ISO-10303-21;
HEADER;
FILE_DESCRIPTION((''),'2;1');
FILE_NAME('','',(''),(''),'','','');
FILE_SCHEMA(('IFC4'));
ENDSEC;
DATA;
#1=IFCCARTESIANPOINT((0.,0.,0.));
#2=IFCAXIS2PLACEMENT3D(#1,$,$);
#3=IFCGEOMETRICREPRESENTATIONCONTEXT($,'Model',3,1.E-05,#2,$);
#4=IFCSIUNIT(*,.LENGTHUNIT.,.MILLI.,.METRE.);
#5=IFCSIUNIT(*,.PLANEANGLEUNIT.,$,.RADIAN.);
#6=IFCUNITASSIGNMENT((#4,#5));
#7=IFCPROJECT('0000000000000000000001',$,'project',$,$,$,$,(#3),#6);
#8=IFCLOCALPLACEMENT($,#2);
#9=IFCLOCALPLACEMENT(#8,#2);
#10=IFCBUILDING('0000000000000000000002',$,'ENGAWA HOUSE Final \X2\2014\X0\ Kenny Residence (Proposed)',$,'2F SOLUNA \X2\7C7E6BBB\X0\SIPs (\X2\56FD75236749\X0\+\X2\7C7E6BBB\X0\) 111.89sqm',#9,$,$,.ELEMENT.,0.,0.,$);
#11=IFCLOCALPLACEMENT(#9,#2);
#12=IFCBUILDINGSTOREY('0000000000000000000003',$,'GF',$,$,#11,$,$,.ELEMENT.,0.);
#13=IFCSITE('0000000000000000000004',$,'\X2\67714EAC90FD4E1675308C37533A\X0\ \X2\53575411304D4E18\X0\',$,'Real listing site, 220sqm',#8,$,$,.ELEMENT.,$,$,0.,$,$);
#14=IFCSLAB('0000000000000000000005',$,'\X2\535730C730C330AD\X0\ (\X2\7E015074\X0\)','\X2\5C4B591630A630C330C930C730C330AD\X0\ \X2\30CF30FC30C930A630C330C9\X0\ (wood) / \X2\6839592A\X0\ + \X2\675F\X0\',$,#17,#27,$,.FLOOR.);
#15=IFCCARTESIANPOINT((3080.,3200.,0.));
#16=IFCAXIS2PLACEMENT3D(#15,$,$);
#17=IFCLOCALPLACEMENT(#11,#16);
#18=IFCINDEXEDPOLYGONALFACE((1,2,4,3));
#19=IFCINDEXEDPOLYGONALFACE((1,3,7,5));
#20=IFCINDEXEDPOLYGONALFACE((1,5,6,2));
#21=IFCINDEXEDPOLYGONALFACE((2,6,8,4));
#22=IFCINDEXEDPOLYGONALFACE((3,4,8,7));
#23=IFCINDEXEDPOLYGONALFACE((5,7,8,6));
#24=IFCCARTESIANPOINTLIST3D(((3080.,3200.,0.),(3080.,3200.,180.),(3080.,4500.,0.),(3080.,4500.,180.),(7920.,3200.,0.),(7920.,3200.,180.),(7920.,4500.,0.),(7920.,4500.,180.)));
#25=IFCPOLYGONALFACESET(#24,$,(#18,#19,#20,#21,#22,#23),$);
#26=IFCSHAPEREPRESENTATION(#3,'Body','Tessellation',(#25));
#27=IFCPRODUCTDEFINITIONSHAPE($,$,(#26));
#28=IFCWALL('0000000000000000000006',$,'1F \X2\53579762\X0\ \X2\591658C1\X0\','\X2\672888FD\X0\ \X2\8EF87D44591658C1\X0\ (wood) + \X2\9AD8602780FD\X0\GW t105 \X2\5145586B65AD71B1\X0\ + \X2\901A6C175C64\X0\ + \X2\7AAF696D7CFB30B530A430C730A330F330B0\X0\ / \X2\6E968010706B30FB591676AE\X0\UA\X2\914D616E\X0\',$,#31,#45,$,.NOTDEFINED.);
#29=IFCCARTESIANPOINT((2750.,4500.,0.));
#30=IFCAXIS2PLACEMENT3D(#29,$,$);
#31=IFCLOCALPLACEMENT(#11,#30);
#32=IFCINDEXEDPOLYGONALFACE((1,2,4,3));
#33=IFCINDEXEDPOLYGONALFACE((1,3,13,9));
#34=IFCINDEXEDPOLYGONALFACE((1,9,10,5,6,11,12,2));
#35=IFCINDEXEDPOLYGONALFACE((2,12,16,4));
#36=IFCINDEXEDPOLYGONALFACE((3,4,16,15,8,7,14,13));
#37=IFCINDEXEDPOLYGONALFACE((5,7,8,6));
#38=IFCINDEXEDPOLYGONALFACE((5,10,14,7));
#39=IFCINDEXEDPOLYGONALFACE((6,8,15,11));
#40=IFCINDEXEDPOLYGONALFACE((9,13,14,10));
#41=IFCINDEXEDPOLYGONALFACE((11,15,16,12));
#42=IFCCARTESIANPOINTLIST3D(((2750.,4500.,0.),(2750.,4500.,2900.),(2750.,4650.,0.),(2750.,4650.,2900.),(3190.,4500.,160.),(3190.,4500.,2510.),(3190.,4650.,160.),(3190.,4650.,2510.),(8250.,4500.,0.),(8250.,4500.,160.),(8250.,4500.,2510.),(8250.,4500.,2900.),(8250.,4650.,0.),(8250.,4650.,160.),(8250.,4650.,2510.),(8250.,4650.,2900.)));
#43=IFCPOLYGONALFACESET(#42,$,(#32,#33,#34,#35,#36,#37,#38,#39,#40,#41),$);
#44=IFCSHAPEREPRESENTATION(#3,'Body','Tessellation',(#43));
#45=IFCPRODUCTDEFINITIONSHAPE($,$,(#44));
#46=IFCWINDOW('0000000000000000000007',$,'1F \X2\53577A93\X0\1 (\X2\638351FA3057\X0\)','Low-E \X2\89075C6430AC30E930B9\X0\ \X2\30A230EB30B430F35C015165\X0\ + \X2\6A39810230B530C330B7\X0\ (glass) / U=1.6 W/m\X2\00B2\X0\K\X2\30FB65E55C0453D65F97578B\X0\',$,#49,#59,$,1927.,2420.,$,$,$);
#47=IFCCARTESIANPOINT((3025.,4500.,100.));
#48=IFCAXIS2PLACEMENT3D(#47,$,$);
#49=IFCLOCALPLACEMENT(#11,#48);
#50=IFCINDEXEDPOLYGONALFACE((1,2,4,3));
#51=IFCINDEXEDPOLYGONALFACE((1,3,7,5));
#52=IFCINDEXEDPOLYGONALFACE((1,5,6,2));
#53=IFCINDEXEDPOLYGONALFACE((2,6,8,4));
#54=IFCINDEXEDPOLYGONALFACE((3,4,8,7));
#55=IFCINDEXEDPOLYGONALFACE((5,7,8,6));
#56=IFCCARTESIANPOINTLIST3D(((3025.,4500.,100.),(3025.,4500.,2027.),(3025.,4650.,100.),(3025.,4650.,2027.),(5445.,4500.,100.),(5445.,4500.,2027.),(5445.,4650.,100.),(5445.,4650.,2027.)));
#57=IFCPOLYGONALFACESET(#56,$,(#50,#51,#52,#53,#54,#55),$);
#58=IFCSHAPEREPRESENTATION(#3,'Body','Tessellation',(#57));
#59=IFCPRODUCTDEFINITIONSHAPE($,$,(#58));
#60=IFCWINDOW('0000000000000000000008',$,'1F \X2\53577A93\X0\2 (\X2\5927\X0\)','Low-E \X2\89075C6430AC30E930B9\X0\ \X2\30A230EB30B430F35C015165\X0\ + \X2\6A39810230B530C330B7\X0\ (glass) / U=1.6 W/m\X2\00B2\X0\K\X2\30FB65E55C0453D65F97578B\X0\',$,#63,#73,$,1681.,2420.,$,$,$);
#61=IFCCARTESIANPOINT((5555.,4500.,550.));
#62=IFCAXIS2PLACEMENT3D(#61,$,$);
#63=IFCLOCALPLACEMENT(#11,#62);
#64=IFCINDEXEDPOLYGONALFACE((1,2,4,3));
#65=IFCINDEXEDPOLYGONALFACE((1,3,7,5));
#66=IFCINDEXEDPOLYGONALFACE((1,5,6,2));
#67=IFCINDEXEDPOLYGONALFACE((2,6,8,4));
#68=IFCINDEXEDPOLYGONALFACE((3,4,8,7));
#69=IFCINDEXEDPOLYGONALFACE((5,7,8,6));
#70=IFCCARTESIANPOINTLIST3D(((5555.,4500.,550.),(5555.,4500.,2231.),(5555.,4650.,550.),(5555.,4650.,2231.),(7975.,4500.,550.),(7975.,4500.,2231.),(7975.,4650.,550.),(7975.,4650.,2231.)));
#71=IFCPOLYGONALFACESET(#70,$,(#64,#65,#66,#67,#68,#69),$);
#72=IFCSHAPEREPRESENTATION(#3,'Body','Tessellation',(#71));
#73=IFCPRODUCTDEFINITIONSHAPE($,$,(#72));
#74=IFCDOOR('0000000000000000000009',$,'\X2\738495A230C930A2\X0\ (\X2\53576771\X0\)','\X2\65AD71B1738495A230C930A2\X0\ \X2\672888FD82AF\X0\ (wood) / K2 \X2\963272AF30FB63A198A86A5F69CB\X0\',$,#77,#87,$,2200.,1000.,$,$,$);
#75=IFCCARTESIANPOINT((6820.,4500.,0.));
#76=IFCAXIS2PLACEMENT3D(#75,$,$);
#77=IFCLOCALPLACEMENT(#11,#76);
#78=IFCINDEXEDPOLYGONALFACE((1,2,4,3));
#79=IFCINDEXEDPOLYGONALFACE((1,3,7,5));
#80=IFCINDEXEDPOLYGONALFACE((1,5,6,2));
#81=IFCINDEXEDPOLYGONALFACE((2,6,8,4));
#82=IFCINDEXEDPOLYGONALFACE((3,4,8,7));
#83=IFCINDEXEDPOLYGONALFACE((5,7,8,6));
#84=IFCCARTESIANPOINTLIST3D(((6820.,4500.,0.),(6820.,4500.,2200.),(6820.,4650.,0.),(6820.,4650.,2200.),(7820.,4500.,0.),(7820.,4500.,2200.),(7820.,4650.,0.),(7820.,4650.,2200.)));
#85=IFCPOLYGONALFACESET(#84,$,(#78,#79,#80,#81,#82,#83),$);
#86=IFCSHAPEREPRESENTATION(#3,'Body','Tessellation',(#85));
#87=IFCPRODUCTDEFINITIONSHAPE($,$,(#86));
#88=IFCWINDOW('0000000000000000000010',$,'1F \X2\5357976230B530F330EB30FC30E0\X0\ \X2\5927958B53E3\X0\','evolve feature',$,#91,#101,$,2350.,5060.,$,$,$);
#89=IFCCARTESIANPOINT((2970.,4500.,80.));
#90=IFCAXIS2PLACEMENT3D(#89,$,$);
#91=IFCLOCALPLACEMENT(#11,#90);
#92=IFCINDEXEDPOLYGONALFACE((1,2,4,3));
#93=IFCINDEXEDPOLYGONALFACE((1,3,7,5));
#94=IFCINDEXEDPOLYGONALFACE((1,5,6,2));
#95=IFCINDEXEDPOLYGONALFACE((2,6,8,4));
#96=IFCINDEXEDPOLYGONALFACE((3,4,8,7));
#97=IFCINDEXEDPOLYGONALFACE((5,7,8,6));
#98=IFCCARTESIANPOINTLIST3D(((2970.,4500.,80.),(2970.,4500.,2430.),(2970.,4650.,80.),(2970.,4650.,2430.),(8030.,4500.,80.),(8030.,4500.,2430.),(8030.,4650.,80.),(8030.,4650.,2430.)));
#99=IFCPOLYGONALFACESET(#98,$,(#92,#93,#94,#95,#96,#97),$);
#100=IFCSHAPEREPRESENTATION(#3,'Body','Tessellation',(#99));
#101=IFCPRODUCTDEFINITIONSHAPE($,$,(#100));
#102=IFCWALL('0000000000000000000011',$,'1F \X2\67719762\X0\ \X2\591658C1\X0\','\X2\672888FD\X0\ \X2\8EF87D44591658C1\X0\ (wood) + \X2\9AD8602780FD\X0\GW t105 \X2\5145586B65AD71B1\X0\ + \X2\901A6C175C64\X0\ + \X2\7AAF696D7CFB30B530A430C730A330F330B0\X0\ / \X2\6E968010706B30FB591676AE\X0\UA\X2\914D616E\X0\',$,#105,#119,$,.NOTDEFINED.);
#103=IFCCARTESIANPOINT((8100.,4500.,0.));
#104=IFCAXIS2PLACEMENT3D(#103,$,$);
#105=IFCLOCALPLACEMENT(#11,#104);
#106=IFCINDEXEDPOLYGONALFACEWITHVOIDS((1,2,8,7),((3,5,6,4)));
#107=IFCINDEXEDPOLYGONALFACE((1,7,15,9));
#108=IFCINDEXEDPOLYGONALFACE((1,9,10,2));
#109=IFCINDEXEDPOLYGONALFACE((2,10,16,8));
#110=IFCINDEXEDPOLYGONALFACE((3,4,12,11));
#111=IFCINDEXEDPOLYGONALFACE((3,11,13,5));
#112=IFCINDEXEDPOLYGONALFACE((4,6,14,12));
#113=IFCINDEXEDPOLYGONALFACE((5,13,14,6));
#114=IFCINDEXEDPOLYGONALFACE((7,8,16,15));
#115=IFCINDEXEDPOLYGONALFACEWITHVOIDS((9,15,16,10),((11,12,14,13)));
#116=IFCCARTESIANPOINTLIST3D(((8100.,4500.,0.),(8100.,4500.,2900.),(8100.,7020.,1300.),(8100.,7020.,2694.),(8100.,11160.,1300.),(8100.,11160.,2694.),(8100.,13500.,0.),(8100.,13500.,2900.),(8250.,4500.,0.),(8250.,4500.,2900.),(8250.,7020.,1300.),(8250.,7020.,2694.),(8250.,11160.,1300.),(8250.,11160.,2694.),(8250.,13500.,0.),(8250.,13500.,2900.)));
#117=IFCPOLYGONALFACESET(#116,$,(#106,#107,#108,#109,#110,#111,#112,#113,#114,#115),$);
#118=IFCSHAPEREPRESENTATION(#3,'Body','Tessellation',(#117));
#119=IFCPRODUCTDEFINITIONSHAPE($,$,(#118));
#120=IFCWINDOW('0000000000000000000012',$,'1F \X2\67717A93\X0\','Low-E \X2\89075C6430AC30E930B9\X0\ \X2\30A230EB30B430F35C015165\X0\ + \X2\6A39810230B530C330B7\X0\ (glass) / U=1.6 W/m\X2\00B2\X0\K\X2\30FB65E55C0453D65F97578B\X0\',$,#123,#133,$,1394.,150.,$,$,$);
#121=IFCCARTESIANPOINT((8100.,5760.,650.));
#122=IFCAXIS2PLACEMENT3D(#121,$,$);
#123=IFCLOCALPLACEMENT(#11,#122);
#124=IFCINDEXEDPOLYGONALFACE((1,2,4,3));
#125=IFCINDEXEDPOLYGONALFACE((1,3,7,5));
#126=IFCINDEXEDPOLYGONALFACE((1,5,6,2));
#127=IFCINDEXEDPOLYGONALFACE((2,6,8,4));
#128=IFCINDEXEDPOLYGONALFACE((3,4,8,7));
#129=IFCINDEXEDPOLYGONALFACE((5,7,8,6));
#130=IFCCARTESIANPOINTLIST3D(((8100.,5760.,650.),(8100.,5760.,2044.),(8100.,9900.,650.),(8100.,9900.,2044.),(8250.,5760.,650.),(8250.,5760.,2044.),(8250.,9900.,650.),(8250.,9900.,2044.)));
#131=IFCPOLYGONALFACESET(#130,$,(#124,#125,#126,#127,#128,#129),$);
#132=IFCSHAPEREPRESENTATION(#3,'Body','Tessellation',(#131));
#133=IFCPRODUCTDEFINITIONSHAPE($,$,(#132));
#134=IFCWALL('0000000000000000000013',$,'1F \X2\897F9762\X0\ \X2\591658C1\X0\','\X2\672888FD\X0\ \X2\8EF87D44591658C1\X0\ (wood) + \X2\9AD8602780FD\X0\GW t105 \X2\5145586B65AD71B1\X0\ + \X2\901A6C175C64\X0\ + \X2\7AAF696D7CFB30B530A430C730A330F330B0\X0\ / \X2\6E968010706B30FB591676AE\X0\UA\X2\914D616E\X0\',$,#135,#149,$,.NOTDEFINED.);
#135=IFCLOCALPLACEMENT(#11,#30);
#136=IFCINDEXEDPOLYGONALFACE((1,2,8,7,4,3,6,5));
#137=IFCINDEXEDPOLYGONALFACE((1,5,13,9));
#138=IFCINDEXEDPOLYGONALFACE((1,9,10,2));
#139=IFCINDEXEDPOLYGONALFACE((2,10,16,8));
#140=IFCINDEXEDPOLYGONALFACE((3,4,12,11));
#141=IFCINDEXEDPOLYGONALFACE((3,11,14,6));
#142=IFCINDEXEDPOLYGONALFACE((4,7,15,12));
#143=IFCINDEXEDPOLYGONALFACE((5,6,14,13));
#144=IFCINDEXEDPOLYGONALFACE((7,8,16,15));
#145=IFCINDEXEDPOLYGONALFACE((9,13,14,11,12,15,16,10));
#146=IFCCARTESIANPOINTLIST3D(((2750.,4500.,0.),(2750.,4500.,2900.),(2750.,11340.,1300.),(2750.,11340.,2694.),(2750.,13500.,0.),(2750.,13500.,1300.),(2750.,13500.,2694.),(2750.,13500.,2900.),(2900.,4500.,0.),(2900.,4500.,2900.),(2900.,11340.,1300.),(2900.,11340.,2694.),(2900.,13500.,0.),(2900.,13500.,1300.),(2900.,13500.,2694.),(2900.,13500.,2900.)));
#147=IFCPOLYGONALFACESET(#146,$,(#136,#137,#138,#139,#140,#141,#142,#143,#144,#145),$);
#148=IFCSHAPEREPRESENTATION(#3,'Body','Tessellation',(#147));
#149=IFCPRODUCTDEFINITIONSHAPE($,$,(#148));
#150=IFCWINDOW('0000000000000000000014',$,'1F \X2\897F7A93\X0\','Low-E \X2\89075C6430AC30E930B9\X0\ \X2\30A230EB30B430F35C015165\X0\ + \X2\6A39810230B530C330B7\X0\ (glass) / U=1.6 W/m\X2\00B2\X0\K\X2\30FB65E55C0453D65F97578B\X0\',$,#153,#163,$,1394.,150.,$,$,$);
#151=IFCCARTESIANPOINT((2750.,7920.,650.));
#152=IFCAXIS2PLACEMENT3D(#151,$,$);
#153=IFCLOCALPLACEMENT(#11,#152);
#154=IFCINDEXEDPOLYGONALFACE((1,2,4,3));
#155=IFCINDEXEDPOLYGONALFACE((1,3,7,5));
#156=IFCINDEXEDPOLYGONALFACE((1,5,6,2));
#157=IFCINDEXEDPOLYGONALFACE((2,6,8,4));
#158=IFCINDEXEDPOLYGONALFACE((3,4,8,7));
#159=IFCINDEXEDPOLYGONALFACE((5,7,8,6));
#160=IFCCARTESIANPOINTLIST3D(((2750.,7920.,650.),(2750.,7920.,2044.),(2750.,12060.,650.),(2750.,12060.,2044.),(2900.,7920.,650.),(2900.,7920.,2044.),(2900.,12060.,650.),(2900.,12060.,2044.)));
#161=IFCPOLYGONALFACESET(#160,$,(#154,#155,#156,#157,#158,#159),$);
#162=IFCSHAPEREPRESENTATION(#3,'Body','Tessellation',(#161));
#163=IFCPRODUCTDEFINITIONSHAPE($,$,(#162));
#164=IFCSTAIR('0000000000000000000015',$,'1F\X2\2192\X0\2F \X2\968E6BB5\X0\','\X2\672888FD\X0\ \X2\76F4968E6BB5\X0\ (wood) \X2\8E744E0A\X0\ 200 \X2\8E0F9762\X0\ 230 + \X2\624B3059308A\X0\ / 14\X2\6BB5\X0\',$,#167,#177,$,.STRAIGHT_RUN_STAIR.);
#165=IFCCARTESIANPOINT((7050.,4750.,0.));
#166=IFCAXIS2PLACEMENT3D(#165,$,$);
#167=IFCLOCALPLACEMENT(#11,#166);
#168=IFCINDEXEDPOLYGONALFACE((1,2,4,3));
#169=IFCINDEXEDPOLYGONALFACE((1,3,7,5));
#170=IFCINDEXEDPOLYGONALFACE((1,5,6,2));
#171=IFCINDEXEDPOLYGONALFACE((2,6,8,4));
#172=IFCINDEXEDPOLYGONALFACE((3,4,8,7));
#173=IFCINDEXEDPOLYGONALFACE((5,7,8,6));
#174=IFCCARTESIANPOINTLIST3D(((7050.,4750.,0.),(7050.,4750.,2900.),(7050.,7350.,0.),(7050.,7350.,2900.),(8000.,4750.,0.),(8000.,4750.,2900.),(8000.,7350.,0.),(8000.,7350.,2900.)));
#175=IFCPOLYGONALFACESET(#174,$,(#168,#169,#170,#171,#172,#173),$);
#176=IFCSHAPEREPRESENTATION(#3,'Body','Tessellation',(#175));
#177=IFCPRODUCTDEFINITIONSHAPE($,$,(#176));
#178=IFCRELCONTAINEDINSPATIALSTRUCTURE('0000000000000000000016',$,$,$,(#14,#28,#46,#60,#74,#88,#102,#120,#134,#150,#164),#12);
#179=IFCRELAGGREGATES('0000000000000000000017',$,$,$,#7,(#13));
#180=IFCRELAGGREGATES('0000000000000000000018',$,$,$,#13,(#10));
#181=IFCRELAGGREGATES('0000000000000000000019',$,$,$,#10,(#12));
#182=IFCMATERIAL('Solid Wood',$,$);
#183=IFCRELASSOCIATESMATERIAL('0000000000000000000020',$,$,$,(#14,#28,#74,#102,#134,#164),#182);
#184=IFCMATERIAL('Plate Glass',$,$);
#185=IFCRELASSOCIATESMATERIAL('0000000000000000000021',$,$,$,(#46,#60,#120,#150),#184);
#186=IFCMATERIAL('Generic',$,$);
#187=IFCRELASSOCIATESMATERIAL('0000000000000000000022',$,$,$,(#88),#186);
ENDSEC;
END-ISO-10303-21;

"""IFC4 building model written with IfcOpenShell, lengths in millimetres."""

from ifc_helpers import new_model, si_unit, frame, frame_2d, origin, place, context, project, spatial, rectangle, extrude, material, element, fill, save


model = new_model("IFC4")

# Units and contexts
model_context = context("Model", 3, precision=1e-05, world=origin())
ifc_project = project(units=[si_unit("LENGTHUNIT", "METRE", prefix="MILLI"), si_unit("PLANEANGLEUNIT", "RADIAN")], contexts=[model_context])

# Site, building, storey
site_placement = place(None, origin())
site = spatial("IfcSite", under=ifc_project, at=site_placement, Name="東京都世田谷区 南向き丘", ObjectType="Real listing site, 220sqm", CompositionType="ELEMENT", RefElevation=0.0)
building_placement = place(site_placement, origin())
building = spatial("IfcBuilding", under=site, at=building_placement, Name="ENGAWA HOUSE Final — Kenny Residence (Proposed)", ObjectType="2F SOLUNA 籾殻SIPs (国産杉+籾殻) 111.89sqm", CompositionType="ELEMENT", ElevationOfRefHeight=0.0, ElevationOfTerrain=0.0)
storey_placement = place(building_placement, origin())
storey = spatial("IfcBuildingStorey", under=building, at=storey_placement, Name="GF", CompositionType="ELEMENT", Elevation=0.0)

# Slab
ifc_material_1 = material(Name="Solid Wood")
slab_1_placement = place(storey_placement, frame((3080.0, 3200.0, 0.0)))
element("IfcSlab", 1, at=slab_1_placement, inside=storey, material=ifc_material_1, Name="南デッキ (縁側)", Description="屋外ウッドデッキ ハードウッド (wood) / 根太 + 束", PredefinedType="FLOOR", context=model_context, shape_type="SweptSolid", body=[
    extrude(rectangle(XDim=4840.0, YDim=1300.0, at=frame_2d((2420.0, 650.0))), frame((3080.0, 3200.0, 0.0)), (0.0, 0.0, 1.0), 180.0),
])
ifc_material_2 = material(Name="Generic")

# Wall, openings, windows, door
wall_1_placement = place(storey_placement, frame((2750.0, 4500.0, 0.0)))
wall_1 = element("IfcWall", 2, at=wall_1_placement, inside=storey, material=ifc_material_1, Name="1F 南面 外壁", Description="木製 軸組外壁 (wood) + 高性能GW t105 充填断熱 + 通気層 + 窯業系サイディング / 準耐火・外皮UA配慮", PredefinedType="NOTDEFINED", context=model_context, shape_type="SweptSolid", body=[
    extrude(rectangle(XDim=5500.0, YDim=150.0, at=frame_2d((2750.0, 75.0))), frame((2750.0, 4500.0, 0.0)), (0.0, 0.0, 1.0), 2900.0),
])
opening_1_placement = place(storey_placement, frame((3025.0, 4500.0, 100.0)))
opening_1 = element("IfcOpeningElement", 3, at=opening_1_placement, cuts=wall_1, PredefinedType="NOTDEFINED", context=model_context, shape_type="SweptSolid", body=[
    extrude(rectangle(XDim=2420.0, YDim=150.0, at=frame_2d((1210.0, 75.0))), frame((3025.0, 4500.0, 100.0)), (0.0, 0.0, 1.0), 1927.0),
])
opening_2_placement = place(storey_placement, frame((5555.0, 4500.0, 550.0)))
opening_2 = element("IfcOpeningElement", 4, at=opening_2_placement, cuts=wall_1, PredefinedType="NOTDEFINED", context=model_context, shape_type="SweptSolid", body=[
    extrude(rectangle(XDim=2420.0, YDim=150.0, at=frame_2d((1210.0, 75.0))), frame((5555.0, 4500.0, 550.0)), (0.0, 0.0, 1.0), 1681.0),
])
opening_3_placement = place(storey_placement, frame((6820.0, 4500.0, 0.0)))
opening_3 = element("IfcOpeningElement", 5, at=opening_3_placement, cuts=wall_1, PredefinedType="NOTDEFINED", context=model_context, shape_type="SweptSolid", body=[
    extrude(rectangle(XDim=1000.0, YDim=150.0, at=frame_2d((500.0, 75.0))), frame((6820.0, 4500.0, 0.0)), (0.0, 0.0, 1.0), 2200.0),
])
opening_4_placement = place(storey_placement, frame((2970.0, 4500.0, 80.0)))
opening_4 = element("IfcOpeningElement", 6, at=opening_4_placement, cuts=wall_1, PredefinedType="NOTDEFINED", context=model_context, shape_type="SweptSolid", body=[
    extrude(rectangle(XDim=5060.0, YDim=150.0, at=frame_2d((2530.0, 75.0))), frame((2970.0, 4500.0, 80.0)), (0.0, 0.0, 1.0), 2350.0),
])
ifc_material_3 = material(Name="Plate Glass")
window_1_placement = place(storey_placement, frame((3025.0, 4500.0, 100.0)))
window_1 = element("IfcWindow", 7, at=window_1_placement, inside=storey, material=ifc_material_3, Name="1F 南窓1 (掃出し)", Description="Low-E 複層ガラス アルゴン封入 + 樹脂サッシ (glass) / U=1.6 W/m²K・日射取得型", OverallHeight=1927.0, OverallWidth=2420.0, context=model_context, shape_type="SweptSolid", body=[
    extrude(rectangle(XDim=2420.0, YDim=150.0, at=frame_2d((1210.0, 75.0))), frame((3025.0, 4500.0, 100.0)), (0.0, 0.0, 1.0), 1927.0),
])
fill(opening_1, window_1)
window_2_placement = place(storey_placement, frame((5555.0, 4500.0, 550.0)))
window_2 = element("IfcWindow", 8, at=window_2_placement, inside=storey, material=ifc_material_3, Name="1F 南窓2 (大)", Description="Low-E 複層ガラス アルゴン封入 + 樹脂サッシ (glass) / U=1.6 W/m²K・日射取得型", OverallHeight=1681.0, OverallWidth=2420.0, context=model_context, shape_type="SweptSolid", body=[
    extrude(rectangle(XDim=2420.0, YDim=150.0, at=frame_2d((1210.0, 75.0))), frame((5555.0, 4500.0, 550.0)), (0.0, 0.0, 1.0), 1681.0),
])
fill(opening_2, window_2)
door_placement = place(storey_placement, frame((6820.0, 4500.0, 0.0)))
door = element("IfcDoor", 9, at=door_placement, inside=storey, material=ifc_material_1, Name="玄関ドア (南東)", Description="断熱玄関ドア 木製芯 (wood) / K2 防犯・採風機構", OverallHeight=2200.0, OverallWidth=1000.0, context=model_context, shape_type="SweptSolid", body=[
    extrude(rectangle(XDim=1000.0, YDim=150.0, at=frame_2d((500.0, 75.0))), frame((6820.0, 4500.0, 0.0)), (0.0, 0.0, 1.0), 2200.0),
])
fill(opening_3, door)
window_3_placement = place(storey_placement, frame((2970.0, 4500.0, 80.0)))
window_3 = element("IfcWindow", 10, at=window_3_placement, inside=storey, material=ifc_material_2, Name="1F 南面サンルーム 大開口", Description="evolve feature", OverallHeight=2350.0, OverallWidth=5060.0, context=model_context, shape_type="SweptSolid", body=[
    extrude(rectangle(XDim=5060.0, YDim=150.0, at=frame_2d((2530.0, 75.0))), frame((2970.0, 4500.0, 80.0)), (0.0, 0.0, 1.0), 2350.0),
])
fill(opening_4, window_3)

# Walls, openings, windows
wall_2_placement = place(storey_placement, frame((8100.0, 4500.0, 0.0)))
wall_2 = element("IfcWall", 11, at=wall_2_placement, inside=storey, material=ifc_material_1, Name="1F 東面 外壁", Description="木製 軸組外壁 (wood) + 高性能GW t105 充填断熱 + 通気層 + 窯業系サイディング / 準耐火・外皮UA配慮", PredefinedType="NOTDEFINED", context=model_context, shape_type="SweptSolid", body=[
    extrude(rectangle(XDim=150.0, YDim=9000.0, at=frame_2d((75.0, 4500.0))), frame((8100.0, 4500.0, 0.0)), (0.0, 0.0, 1.0), 2900.0),
])
opening_5_placement = place(storey_placement, frame((8100.0, 5760.0, 650.0)))
opening_5 = element("IfcOpeningElement", 12, at=opening_5_placement, cuts=wall_2, PredefinedType="NOTDEFINED", context=model_context, shape_type="SweptSolid", body=[
    extrude(rectangle(XDim=150.0, YDim=4140.0, at=frame_2d((75.0, 2070.0))), frame((8100.0, 5760.0, 650.0)), (0.0, 0.0, 1.0), 1394.0),
])
window_4_placement = place(storey_placement, frame((8100.0, 5760.0, 650.0)))
window_4 = element("IfcWindow", 13, at=window_4_placement, inside=storey, material=ifc_material_3, Name="1F 東窓", Description="Low-E 複層ガラス アルゴン封入 + 樹脂サッシ (glass) / U=1.6 W/m²K・日射取得型", OverallHeight=1394.0, OverallWidth=150.0, context=model_context, shape_type="SweptSolid", body=[
    extrude(rectangle(XDim=150.0, YDim=4140.0, at=frame_2d((75.0, 2070.0))), frame((8100.0, 5760.0, 650.0)), (0.0, 0.0, 1.0), 1394.0),
])
fill(opening_5, window_4)
wall_3_placement = place(storey_placement, frame((2750.0, 4500.0, 0.0)))
wall_3 = element("IfcWall", 14, at=wall_3_placement, inside=storey, material=ifc_material_1, Name="1F 西面 外壁", Description="木製 軸組外壁 (wood) + 高性能GW t105 充填断熱 + 通気層 + 窯業系サイディング / 準耐火・外皮UA配慮", PredefinedType="NOTDEFINED", context=model_context, shape_type="SweptSolid", body=[
    extrude(rectangle(XDim=150.0, YDim=9000.0, at=frame_2d((75.0, 4500.0))), frame((2750.0, 4500.0, 0.0)), (0.0, 0.0, 1.0), 2900.0),
])
opening_6_placement = place(storey_placement, frame((2750.0, 7920.0, 650.0)))
opening_6 = element("IfcOpeningElement", 15, at=opening_6_placement, cuts=wall_3, PredefinedType="NOTDEFINED", context=model_context, shape_type="SweptSolid", body=[
    extrude(rectangle(XDim=150.0, YDim=4140.0, at=frame_2d((75.0, 2070.0))), frame((2750.0, 7920.0, 650.0)), (0.0, 0.0, 1.0), 1394.0),
])
window_5_placement = place(storey_placement, frame((2750.0, 7920.0, 650.0)))
window_5 = element("IfcWindow", 16, at=window_5_placement, inside=storey, material=ifc_material_3, Name="1F 西窓", Description="Low-E 複層ガラス アルゴン封入 + 樹脂サッシ (glass) / U=1.6 W/m²K・日射取得型", OverallHeight=1394.0, OverallWidth=150.0, context=model_context, shape_type="SweptSolid", body=[
    extrude(rectangle(XDim=150.0, YDim=4140.0, at=frame_2d((75.0, 2070.0))), frame((2750.0, 7920.0, 650.0)), (0.0, 0.0, 1.0), 1394.0),
])
fill(opening_6, window_5)

# Stair
stair_placement = place(storey_placement, frame((7050.0, 4750.0, 0.0)))
element("IfcStair", 17, at=stair_placement, inside=storey, material=ifc_material_1, Name="1F→2F 階段", Description="木製 直階段 (wood) 蹴上 200 踏面 230 + 手すり / 14段", PredefinedType="STRAIGHT_RUN_STAIR", context=model_context, shape_type="SweptSolid", body=[
    extrude(rectangle(XDim=950.0, YDim=2600.0, at=frame_2d((475.0, 1300.0))), frame((7050.0, 4750.0, 0.0)), (0.0, 0.0, 1.0), 2900.0),
])

save(model, "model.ifc")
